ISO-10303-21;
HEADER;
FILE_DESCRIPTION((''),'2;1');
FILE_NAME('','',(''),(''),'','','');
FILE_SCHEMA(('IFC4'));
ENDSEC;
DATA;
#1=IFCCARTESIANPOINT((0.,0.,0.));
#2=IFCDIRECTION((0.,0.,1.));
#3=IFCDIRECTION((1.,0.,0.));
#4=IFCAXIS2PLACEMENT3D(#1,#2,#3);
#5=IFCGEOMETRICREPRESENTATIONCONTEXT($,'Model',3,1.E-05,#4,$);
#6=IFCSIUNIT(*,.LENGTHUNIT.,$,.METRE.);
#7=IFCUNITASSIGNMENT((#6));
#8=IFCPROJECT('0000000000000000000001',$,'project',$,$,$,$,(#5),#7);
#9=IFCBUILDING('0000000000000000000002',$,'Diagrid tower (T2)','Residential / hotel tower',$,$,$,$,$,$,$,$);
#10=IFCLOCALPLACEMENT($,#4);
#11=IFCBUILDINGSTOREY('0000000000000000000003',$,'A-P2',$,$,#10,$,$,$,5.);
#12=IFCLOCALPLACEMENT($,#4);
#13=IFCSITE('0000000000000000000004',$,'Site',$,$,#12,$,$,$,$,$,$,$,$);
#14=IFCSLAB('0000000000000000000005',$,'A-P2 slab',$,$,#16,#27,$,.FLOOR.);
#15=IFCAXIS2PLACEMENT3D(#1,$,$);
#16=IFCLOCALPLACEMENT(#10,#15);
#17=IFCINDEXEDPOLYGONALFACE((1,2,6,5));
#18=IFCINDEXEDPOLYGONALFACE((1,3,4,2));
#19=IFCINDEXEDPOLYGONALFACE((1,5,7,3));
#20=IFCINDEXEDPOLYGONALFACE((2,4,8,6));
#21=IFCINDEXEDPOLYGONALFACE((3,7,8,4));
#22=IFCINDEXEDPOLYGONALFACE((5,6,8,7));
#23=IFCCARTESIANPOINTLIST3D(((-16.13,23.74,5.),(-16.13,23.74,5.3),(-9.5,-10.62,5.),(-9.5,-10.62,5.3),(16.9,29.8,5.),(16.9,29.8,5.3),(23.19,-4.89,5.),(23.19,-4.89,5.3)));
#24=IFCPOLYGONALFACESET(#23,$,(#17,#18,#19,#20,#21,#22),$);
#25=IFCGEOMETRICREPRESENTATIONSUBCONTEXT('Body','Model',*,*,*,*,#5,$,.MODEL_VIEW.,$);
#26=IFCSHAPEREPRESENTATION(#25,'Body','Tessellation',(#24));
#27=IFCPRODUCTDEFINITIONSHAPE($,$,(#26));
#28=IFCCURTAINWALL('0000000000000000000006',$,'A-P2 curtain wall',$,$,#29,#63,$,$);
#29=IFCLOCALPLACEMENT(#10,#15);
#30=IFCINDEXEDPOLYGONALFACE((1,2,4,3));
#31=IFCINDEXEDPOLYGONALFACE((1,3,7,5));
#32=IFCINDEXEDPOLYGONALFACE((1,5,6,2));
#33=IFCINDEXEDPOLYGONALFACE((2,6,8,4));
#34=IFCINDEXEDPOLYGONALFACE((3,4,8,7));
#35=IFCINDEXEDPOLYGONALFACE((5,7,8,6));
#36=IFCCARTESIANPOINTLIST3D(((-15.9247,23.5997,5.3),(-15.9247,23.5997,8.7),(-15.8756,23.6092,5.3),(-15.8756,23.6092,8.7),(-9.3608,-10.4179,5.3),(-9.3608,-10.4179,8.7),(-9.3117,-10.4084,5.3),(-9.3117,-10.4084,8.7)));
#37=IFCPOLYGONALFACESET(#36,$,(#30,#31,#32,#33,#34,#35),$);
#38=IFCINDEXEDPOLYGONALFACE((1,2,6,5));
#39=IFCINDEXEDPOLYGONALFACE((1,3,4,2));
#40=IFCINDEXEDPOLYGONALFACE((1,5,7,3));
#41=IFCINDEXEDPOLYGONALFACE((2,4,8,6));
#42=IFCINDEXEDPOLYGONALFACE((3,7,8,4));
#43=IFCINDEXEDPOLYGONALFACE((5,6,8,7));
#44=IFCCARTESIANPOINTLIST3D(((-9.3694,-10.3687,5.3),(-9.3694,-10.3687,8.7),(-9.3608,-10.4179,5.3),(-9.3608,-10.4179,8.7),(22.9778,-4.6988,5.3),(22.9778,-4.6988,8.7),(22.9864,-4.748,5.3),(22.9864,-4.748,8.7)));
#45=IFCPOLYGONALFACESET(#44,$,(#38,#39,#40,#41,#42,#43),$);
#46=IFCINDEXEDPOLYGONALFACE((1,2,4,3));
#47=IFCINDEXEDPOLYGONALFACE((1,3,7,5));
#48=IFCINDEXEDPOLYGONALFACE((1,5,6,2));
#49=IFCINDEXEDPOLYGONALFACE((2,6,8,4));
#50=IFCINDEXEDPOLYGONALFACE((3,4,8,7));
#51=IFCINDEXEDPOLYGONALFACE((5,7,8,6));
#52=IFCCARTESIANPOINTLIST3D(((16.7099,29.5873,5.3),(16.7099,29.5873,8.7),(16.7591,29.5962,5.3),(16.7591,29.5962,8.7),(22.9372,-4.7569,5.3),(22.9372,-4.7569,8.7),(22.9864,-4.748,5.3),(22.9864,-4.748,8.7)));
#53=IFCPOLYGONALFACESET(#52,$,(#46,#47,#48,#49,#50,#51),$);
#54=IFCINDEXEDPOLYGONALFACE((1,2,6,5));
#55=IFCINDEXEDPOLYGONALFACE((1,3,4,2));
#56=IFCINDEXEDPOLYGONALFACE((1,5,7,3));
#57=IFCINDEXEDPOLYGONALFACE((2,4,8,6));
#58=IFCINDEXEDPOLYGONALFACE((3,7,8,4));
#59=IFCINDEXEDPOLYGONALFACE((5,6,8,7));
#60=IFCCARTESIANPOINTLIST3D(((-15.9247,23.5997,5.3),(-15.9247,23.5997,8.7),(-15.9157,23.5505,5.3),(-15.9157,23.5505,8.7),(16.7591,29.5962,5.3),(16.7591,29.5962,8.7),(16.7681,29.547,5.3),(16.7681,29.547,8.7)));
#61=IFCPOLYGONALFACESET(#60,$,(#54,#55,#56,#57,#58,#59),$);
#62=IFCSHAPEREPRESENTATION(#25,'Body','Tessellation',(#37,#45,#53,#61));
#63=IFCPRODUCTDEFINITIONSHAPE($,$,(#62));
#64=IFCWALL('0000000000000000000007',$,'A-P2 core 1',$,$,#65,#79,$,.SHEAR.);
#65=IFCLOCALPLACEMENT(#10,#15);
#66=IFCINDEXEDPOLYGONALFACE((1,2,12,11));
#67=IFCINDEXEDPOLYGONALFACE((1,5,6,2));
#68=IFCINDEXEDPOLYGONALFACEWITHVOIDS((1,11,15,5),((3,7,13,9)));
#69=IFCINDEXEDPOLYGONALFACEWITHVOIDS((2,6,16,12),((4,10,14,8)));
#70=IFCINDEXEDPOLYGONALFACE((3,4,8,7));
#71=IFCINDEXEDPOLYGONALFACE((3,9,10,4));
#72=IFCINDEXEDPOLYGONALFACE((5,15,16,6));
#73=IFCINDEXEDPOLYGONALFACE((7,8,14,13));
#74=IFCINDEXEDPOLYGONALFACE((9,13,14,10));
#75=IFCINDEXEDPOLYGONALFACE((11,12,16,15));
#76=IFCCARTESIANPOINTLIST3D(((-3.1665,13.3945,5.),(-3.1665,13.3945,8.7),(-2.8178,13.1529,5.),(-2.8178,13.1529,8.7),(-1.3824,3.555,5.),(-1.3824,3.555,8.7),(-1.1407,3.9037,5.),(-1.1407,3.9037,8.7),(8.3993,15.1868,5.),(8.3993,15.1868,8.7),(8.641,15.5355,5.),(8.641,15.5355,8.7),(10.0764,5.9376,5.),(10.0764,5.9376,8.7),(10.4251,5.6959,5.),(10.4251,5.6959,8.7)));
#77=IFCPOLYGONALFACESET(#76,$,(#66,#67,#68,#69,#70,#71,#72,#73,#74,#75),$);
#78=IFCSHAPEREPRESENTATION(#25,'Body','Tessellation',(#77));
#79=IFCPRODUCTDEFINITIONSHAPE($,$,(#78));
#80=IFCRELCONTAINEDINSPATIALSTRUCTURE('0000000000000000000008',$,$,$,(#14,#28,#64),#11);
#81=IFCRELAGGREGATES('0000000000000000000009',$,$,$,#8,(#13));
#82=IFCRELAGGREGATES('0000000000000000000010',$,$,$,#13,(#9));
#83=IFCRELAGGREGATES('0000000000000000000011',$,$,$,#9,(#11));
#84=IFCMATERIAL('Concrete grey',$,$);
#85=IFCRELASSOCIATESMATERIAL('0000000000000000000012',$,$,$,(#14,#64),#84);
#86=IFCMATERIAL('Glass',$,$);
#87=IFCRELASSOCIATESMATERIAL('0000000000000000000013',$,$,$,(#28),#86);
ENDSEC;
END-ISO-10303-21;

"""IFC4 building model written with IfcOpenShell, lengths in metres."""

from ifc_helpers import new_model, si_unit, frame, origin_with_axes, place, context, subcontext, project, spatial, polyline, outline, extrude, material, element, save


model = new_model("IFC4")

# Units and contexts
model_context = context("Model", 3, precision=1e-05, world=origin_with_axes())
body_context = subcontext(model_context, "Body", "Model", "MODEL_VIEW")
ifc_project = project(units=[si_unit("LENGTHUNIT", "METRE")], contexts=[model_context])

# Site, building, storey
site_placement = place(None, origin_with_axes())
site = spatial("IfcSite", under=ifc_project, at=site_placement, Name="Site")
building = spatial("IfcBuilding", under=site, Name="Diagrid tower (T2)", Description="Residential / hotel tower")
storey_placement = place(None, origin_with_axes())
storey = spatial("IfcBuildingStorey", under=building, at=storey_placement, Name="A-P2", Elevation=5.0)

# Slab
ifc_material_1 = material(Name="Concrete grey")
slab_placement = place(storey_placement, origin_with_axes())
element("IfcSlab", 1, at=slab_placement, inside=storey, material=ifc_material_1, Name="A-P2 slab", PredefinedType="FLOOR", context=body_context, shape_type="SweptSolid", body=[
    extrude(outline(polyline([(-16.13, 23.74), (-9.5, -10.62), (23.19, -4.89), (16.9, 29.8), (-16.13, 23.74)])), frame((0.0, 0.0, 5.0), z_axis=(0.0, 0.0, 1.0), x_axis=(1.0, 0.0, 0.0)), (0.0, 0.0, 1.0), 0.3),
])

# Curtain wall
ifc_material_2 = material(Name="Glass")
curtain_wall_placement = place(storey_placement, origin_with_axes())
element("IfcCurtainWall", 2, at=curtain_wall_placement, inside=storey, material=ifc_material_2, Name="A-P2 curtain wall", context=body_context, shape_type="SweptSolid", body=[
    extrude(outline(polyline([(-15.9247, 23.5997), (-9.3608, -10.4179), (-9.3117, -10.4084), (-15.8756, 23.6092), (-15.9247, 23.5997)])), frame((0.0, 0.0, 5.3), z_axis=(0.0, 0.0, 1.0), x_axis=(1.0, 0.0, 0.0)), (0.0, 0.0, 1.0), 3.4),
    extrude(outline(polyline([(-9.3608, -10.4179), (22.9864, -4.748), (22.9778, -4.6988), (-9.3694, -10.3687), (-9.3608, -10.4179)])), frame((0.0, 0.0, 5.3), z_axis=(0.0, 0.0, 1.0), x_axis=(1.0, 0.0, 0.0)), (0.0, 0.0, 1.0), 3.4),
    extrude(outline(polyline([(22.9864, -4.748), (16.7591, 29.5962), (16.7099, 29.5873), (22.9372, -4.7569), (22.9864, -4.748)])), frame((0.0, 0.0, 5.3), z_axis=(0.0, 0.0, 1.0), x_axis=(1.0, 0.0, 0.0)), (0.0, 0.0, 1.0), 3.4),
    extrude(outline(polyline([(16.7591, 29.5962), (-15.9247, 23.5997), (-15.9157, 23.5505), (16.7681, 29.547), (16.7591, 29.5962)])), frame((0.0, 0.0, 5.3), z_axis=(0.0, 0.0, 1.0), x_axis=(1.0, 0.0, 0.0)), (0.0, 0.0, 1.0), 3.4),
])

# Wall
wall_placement = place(storey_placement, origin_with_axes())
element("IfcWall", 3, at=wall_placement, inside=storey, material=ifc_material_1, Name="A-P2 core 1", PredefinedType="SHEAR", context=body_context, shape_type="SweptSolid", body=[
    extrude(outline(polyline([(10.4251, 5.6959), (8.641, 15.5355), (-3.1665, 13.3945), (-1.3824, 3.555), (10.4251, 5.6959)]), holes=[polyline([(10.0764, 5.9376), (8.3993, 15.1868), (-2.8178, 13.1529), (-1.1407, 3.9037), (10.0764, 5.9376)])]), frame((0.0, 0.0, 5.0), z_axis=(0.0, 0.0, 1.0), x_axis=(1.0, 0.0, 0.0)), (0.0, 0.0, 1.0), 3.7),
])

save(model, "model.ifc")
